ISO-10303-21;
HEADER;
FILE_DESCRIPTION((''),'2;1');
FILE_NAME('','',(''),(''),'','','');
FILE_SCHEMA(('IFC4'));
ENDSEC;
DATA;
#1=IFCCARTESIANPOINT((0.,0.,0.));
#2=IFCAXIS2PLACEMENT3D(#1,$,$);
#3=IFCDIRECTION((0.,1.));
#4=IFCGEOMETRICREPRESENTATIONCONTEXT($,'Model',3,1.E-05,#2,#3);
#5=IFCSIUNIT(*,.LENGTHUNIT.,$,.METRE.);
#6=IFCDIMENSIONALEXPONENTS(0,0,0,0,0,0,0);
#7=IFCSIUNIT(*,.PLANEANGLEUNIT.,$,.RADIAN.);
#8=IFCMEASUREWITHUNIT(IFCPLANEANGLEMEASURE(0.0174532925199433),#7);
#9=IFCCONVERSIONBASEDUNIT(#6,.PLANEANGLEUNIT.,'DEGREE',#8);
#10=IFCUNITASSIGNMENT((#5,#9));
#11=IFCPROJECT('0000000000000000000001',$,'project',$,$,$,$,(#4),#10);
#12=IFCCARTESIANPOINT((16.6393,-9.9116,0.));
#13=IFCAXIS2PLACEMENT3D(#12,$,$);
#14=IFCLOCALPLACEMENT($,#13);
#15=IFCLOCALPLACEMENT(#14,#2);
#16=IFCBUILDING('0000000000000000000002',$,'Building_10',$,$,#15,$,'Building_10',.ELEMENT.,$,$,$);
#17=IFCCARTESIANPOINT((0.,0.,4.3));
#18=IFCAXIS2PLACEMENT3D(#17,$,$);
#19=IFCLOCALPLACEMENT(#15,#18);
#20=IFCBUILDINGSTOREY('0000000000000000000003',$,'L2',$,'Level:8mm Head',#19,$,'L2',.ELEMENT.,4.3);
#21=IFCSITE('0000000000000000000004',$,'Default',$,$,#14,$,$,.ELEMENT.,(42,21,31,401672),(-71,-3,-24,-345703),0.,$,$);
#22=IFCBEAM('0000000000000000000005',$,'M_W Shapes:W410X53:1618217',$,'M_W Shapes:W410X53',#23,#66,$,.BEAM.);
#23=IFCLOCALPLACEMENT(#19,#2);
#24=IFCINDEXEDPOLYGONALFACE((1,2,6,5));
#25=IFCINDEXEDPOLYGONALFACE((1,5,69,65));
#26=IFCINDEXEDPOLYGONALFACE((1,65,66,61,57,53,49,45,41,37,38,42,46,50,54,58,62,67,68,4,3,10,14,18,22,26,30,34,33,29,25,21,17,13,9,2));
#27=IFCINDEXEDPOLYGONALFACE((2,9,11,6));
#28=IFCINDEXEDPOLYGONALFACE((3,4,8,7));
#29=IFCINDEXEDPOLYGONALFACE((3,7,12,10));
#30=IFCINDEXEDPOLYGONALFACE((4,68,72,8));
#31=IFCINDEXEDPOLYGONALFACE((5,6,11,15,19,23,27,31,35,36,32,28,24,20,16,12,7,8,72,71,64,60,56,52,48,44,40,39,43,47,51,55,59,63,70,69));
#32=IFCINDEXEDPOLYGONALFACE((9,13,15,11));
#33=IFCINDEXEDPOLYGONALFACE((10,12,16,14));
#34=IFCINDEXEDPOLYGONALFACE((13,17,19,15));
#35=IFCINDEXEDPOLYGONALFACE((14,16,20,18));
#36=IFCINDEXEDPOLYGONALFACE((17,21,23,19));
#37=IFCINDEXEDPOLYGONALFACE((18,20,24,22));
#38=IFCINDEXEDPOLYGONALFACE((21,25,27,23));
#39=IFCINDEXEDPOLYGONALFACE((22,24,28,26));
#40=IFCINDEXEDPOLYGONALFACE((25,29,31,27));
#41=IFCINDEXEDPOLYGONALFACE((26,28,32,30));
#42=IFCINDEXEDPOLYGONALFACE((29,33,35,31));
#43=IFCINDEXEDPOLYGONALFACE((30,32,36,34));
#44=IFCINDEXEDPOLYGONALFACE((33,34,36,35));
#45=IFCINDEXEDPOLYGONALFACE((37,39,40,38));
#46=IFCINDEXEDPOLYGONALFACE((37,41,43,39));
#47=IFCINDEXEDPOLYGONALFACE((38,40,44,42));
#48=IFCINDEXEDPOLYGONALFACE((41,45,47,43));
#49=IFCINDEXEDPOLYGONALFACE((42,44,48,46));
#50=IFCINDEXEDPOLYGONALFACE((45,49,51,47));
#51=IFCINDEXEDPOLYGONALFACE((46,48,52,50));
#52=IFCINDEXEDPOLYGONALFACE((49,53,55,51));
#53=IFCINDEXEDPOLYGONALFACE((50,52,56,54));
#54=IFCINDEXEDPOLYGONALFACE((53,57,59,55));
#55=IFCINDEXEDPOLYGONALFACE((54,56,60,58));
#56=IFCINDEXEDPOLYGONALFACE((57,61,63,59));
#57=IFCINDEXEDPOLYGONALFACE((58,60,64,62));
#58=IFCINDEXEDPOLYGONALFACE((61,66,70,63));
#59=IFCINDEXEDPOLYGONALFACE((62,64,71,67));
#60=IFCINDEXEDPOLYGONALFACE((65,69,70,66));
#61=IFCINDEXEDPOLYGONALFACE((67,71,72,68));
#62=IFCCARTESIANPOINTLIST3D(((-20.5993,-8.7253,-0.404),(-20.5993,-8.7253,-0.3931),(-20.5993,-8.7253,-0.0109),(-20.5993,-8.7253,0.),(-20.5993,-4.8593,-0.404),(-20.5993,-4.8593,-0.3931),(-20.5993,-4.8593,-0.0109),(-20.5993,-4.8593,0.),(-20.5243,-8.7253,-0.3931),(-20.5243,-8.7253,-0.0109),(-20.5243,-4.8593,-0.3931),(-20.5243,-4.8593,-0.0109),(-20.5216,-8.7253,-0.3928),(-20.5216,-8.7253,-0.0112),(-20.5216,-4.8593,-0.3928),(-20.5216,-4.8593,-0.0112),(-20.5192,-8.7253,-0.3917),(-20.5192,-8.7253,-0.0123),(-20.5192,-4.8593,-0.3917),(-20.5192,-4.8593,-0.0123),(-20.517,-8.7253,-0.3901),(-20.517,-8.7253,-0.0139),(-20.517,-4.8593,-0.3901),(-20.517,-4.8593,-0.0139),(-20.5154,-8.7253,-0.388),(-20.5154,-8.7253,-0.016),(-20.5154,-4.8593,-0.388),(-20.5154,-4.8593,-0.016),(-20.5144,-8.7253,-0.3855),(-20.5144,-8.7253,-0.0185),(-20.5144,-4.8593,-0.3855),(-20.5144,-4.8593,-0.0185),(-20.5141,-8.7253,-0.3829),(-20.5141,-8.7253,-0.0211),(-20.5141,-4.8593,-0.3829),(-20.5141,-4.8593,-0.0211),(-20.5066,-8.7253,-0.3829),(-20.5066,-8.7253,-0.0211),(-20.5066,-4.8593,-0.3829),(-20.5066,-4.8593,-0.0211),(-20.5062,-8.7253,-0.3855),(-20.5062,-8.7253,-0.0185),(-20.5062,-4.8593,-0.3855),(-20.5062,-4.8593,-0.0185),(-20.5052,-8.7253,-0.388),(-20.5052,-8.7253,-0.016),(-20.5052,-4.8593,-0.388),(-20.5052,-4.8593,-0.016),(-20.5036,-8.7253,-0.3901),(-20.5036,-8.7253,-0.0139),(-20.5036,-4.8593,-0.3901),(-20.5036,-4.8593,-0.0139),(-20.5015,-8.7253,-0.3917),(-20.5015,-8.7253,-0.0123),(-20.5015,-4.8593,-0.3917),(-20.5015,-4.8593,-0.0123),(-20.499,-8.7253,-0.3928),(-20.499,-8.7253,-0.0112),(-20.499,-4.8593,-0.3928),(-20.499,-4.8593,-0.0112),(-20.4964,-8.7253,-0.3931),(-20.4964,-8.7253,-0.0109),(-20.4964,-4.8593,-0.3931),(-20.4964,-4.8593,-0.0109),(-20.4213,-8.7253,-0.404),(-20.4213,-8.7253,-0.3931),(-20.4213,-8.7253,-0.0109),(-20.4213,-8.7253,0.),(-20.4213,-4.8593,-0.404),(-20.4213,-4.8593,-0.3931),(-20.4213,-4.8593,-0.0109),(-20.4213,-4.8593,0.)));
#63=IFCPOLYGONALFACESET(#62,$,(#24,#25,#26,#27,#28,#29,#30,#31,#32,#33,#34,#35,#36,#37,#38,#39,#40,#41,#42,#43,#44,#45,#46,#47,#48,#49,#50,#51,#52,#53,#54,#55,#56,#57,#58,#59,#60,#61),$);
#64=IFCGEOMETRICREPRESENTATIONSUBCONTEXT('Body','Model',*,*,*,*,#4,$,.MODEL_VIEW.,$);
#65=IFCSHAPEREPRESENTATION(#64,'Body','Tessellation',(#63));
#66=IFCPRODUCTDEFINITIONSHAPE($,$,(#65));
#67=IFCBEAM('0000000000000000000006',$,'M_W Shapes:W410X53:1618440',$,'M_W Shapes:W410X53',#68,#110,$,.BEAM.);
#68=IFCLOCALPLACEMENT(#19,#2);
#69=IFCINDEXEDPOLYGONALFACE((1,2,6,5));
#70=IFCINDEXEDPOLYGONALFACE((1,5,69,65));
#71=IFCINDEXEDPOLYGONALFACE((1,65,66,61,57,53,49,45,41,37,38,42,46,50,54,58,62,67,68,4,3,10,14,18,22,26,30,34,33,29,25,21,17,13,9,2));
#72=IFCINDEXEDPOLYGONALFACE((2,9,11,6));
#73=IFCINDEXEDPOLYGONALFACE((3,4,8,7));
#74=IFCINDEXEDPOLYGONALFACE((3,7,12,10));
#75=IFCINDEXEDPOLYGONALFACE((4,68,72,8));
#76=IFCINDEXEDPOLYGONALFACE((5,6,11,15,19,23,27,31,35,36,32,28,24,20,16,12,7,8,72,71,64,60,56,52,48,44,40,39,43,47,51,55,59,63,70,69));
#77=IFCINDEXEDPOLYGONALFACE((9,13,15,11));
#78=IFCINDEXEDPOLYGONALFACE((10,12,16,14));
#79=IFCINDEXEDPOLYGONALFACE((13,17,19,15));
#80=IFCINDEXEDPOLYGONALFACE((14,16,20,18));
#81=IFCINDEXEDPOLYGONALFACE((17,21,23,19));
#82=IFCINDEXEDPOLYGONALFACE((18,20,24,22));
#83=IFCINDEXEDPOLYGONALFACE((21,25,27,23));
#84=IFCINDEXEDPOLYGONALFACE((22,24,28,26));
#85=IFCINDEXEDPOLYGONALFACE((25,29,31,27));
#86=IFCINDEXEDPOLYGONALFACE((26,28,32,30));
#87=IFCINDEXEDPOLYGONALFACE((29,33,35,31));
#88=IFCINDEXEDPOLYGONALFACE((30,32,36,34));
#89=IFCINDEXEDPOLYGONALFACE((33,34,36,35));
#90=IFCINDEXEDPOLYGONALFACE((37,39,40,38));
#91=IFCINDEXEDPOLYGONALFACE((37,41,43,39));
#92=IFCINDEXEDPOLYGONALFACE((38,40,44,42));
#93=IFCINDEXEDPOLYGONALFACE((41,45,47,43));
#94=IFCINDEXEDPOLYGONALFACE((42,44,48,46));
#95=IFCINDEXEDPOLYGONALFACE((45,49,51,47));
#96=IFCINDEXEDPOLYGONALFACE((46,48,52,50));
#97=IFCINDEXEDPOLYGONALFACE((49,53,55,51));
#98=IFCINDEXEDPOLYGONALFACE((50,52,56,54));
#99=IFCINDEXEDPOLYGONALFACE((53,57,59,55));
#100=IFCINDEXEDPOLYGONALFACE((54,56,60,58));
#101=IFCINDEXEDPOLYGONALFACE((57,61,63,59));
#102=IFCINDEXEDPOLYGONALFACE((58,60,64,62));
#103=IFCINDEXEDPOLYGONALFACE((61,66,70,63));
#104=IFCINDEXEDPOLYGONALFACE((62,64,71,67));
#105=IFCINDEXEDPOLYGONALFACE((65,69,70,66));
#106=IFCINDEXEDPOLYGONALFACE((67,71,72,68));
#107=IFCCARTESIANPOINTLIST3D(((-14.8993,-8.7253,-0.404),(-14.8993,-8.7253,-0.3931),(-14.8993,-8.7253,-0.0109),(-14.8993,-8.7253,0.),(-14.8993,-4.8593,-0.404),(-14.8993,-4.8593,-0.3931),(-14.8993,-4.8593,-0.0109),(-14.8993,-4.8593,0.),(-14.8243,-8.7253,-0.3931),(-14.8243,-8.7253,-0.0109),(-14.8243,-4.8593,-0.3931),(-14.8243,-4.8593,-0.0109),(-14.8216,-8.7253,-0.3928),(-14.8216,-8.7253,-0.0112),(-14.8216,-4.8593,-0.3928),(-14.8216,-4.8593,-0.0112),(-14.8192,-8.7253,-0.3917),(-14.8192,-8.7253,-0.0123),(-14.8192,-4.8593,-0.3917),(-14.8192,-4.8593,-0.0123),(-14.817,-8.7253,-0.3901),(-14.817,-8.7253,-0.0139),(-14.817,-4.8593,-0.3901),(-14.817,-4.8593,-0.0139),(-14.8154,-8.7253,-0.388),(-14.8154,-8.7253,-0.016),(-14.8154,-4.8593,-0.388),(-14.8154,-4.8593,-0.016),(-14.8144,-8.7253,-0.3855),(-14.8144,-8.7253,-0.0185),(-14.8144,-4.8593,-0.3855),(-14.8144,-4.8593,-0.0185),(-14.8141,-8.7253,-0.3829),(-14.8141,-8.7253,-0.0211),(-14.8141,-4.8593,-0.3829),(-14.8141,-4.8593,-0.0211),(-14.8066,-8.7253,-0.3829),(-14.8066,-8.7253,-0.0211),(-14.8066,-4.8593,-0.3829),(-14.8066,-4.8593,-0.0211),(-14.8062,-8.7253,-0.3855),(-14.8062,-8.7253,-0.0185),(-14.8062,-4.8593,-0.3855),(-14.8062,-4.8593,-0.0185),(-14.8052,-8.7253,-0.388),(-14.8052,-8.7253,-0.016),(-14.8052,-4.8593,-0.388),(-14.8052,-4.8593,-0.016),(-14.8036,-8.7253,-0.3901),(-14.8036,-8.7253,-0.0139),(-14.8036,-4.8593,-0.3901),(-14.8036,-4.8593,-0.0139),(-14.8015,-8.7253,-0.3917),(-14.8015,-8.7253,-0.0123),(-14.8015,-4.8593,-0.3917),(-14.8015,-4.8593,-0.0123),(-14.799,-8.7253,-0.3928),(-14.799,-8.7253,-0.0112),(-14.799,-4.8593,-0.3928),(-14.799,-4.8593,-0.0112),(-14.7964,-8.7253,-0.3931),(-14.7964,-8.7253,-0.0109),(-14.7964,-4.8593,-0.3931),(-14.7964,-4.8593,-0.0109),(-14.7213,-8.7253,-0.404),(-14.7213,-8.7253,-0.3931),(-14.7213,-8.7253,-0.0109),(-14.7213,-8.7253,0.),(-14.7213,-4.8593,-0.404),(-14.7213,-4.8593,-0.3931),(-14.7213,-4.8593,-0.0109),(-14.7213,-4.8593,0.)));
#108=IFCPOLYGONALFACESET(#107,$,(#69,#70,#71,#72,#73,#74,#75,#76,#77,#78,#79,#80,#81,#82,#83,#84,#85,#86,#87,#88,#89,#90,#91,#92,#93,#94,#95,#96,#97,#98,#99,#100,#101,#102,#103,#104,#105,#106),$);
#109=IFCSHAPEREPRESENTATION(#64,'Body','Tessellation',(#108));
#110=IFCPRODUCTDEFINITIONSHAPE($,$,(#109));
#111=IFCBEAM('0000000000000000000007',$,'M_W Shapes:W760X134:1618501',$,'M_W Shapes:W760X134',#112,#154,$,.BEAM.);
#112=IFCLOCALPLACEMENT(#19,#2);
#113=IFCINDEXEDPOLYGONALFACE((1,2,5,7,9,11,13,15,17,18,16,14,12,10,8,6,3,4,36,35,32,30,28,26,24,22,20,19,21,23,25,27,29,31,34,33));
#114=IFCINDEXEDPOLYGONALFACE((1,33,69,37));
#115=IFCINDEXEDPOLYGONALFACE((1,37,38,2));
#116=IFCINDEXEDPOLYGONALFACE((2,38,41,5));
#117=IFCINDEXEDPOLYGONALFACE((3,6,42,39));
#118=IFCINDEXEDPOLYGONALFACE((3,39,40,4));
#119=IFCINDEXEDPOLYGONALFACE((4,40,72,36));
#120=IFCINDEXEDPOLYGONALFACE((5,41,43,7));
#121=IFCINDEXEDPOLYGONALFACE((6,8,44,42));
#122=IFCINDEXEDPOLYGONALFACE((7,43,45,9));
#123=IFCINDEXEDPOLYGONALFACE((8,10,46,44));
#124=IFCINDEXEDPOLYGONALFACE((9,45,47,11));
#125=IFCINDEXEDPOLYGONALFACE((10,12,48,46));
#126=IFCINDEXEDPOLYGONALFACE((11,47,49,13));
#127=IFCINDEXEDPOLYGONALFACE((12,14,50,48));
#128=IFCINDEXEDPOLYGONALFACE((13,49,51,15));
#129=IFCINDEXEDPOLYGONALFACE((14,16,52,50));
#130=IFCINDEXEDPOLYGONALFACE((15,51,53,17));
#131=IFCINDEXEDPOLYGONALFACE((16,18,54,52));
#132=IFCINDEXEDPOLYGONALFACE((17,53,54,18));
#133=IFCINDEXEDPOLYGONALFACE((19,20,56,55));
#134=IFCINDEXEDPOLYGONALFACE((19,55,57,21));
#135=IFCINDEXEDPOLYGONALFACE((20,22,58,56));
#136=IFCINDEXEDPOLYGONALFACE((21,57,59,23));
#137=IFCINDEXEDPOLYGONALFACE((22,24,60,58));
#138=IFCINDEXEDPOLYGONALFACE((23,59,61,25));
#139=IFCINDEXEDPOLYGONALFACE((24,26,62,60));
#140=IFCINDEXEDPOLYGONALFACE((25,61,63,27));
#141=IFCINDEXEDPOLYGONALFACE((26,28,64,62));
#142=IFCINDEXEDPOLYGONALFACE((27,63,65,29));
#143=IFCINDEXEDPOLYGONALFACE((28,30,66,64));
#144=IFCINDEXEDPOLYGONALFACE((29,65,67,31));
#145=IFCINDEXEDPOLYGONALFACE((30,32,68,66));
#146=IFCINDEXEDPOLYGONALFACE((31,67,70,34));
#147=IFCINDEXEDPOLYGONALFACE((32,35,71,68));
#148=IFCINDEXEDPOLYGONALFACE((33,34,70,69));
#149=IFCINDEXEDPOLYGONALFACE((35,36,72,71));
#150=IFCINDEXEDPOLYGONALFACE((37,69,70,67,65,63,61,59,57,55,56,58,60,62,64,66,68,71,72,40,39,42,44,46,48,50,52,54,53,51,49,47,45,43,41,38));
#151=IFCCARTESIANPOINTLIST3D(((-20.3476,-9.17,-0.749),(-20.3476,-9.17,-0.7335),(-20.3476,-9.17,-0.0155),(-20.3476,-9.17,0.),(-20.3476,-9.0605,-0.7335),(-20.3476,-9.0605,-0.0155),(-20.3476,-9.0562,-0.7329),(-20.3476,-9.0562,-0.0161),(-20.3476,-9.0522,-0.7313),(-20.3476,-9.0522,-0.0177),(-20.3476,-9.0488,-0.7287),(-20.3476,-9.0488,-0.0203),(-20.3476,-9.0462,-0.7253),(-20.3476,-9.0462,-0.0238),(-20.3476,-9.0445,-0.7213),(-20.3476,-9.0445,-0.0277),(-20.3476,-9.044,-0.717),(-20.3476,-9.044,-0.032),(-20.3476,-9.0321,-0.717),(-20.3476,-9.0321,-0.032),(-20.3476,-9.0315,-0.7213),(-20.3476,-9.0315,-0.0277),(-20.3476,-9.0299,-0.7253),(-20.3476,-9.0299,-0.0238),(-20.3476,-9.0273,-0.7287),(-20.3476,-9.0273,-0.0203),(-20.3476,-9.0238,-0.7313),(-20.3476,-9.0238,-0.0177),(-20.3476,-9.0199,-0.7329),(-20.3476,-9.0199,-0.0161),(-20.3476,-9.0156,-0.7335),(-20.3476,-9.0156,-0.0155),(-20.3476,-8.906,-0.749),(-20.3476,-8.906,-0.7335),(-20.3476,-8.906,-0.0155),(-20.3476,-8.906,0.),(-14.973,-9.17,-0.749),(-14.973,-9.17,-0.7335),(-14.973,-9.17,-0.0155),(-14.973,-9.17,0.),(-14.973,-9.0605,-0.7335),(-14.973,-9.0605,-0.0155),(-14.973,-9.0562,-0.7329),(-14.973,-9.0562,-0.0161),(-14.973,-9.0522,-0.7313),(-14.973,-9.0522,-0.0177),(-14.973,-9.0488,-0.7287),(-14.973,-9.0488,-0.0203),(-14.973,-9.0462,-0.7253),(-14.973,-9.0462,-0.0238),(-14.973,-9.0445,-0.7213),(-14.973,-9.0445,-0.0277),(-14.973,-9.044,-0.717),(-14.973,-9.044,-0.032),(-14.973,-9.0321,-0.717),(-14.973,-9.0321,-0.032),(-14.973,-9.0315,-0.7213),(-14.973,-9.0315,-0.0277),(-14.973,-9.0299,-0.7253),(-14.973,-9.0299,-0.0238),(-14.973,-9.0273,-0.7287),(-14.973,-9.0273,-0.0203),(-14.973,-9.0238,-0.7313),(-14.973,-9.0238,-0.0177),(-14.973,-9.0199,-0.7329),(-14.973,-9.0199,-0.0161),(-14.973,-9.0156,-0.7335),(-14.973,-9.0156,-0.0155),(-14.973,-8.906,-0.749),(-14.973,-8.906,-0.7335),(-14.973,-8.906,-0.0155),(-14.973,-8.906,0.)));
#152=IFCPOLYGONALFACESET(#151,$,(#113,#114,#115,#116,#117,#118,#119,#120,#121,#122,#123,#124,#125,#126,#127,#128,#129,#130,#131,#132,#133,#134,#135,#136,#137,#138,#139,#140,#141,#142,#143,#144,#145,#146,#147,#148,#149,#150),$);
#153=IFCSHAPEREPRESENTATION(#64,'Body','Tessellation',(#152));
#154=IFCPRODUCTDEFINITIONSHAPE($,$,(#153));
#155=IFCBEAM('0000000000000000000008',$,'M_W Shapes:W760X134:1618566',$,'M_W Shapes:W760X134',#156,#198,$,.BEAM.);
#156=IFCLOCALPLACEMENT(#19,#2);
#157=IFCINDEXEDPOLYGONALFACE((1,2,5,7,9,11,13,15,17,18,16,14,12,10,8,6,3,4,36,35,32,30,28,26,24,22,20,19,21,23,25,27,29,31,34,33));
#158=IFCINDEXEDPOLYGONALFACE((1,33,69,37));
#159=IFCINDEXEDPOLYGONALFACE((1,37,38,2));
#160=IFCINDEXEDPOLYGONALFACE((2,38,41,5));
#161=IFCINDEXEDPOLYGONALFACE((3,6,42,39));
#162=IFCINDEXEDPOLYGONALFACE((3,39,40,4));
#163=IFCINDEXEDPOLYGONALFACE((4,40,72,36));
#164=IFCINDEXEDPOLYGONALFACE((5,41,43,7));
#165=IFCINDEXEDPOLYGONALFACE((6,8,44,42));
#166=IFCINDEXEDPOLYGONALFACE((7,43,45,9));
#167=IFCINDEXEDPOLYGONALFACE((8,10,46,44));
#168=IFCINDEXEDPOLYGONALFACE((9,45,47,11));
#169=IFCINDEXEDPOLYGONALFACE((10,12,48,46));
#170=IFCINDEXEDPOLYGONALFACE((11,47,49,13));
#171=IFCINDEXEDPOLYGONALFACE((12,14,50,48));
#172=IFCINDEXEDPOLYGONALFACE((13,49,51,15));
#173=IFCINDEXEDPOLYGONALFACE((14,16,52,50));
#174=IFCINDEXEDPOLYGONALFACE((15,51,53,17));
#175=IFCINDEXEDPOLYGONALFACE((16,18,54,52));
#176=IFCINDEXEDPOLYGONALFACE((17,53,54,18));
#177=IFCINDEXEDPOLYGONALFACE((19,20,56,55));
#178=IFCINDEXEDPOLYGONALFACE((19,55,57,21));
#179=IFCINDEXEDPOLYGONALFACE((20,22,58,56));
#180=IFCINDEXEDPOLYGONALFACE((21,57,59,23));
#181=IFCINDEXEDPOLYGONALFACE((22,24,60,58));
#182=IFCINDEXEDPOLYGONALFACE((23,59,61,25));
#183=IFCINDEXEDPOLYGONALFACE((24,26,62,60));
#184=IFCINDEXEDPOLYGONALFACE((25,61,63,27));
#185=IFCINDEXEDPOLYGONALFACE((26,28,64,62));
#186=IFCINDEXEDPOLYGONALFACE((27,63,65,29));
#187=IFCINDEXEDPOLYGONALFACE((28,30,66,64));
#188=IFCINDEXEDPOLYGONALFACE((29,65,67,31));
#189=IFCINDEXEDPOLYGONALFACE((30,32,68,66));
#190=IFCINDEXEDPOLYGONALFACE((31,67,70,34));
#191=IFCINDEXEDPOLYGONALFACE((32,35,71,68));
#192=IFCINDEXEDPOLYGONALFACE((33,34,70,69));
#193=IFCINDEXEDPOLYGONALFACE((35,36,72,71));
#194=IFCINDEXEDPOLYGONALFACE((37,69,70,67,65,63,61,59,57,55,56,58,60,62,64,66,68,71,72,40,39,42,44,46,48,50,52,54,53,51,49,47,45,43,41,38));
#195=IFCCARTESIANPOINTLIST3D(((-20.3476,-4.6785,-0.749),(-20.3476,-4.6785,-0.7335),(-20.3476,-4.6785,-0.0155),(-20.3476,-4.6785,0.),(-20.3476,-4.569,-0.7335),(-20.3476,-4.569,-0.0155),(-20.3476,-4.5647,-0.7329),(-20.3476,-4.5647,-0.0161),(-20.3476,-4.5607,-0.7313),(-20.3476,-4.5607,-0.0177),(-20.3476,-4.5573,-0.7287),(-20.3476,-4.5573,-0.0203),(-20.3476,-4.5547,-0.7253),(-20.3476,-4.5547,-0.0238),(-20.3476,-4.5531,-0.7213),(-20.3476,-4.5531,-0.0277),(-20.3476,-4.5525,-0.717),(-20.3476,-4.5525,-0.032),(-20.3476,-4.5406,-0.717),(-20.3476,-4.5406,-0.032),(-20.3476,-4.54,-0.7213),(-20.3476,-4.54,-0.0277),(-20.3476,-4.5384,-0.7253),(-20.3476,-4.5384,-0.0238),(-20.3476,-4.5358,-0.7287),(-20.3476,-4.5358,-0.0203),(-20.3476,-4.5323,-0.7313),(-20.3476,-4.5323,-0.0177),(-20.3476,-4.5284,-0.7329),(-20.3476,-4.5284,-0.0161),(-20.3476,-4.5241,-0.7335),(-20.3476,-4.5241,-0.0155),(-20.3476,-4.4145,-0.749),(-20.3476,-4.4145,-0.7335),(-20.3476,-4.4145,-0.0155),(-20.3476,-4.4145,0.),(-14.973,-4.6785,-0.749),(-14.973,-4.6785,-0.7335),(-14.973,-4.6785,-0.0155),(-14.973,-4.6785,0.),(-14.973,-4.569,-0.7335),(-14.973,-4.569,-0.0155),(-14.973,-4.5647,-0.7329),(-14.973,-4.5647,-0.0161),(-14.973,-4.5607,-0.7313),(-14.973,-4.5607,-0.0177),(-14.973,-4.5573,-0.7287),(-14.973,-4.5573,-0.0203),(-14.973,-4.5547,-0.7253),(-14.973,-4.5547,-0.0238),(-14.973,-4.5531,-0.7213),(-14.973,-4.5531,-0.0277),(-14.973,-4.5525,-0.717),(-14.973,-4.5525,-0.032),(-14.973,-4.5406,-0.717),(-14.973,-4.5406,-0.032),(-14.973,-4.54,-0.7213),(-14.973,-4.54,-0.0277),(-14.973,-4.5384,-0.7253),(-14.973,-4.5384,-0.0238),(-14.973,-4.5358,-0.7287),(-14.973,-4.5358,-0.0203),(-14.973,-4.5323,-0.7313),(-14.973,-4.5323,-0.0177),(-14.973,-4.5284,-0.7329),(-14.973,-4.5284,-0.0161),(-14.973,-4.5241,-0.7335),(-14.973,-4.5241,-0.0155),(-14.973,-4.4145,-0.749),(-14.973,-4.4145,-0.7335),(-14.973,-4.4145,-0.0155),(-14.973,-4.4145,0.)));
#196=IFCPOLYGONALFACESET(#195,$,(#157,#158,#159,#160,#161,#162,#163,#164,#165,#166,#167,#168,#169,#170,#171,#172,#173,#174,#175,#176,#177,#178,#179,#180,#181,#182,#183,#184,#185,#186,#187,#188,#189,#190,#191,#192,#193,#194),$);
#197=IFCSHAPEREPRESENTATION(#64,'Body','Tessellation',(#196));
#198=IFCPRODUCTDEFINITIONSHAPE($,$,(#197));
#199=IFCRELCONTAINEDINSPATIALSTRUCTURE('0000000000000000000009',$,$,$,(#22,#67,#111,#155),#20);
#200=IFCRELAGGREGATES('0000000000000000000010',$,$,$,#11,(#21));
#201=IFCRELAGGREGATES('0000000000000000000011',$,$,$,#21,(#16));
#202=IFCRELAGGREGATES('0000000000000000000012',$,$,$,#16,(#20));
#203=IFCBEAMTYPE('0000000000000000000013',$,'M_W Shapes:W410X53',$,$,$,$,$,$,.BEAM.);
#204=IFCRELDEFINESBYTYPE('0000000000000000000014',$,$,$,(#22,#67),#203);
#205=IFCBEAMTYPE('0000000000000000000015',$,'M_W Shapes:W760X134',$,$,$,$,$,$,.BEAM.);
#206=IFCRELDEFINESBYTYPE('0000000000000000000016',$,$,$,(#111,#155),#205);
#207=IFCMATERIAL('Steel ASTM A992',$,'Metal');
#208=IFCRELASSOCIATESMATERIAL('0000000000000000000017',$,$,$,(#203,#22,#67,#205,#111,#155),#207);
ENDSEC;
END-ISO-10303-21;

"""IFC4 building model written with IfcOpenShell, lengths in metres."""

from ifc_helpers import new_model, entity, si_unit, converted_unit, direction, frame, origin, place, context, subcontext, project, spatial, line, arc, indexed_curve, outline, extrude, source, transform, mapped, material, type_object, type_shapes, element, save


model = new_model("IFC4")

# Units and contexts
model_context = context("Model", 3, precision=1e-05, world=origin(), true_north=direction((0.0, 1.0)))
body_context = subcontext(model_context, "Body", "Model", "MODEL_VIEW")
ifc_project = project(units=[si_unit("LENGTHUNIT", "METRE"), converted_unit("PLANEANGLEUNIT", "DEGREE", entity("IfcPlaneAngleMeasure", 0.0174532925199433), si_unit("PLANEANGLEUNIT", "RADIAN"), dimensions=[0, 0, 0, 0, 0, 0, 0])], contexts=[model_context])

# Site, building, storey
site_placement = place(None, frame((16.6393, -9.9116, 0.0)))
site = spatial("IfcSite", under=ifc_project, at=site_placement, Name="Default", CompositionType="ELEMENT", RefLatitude=(42, 21, 31, 401672), RefLongitude=(-71, -3, -24, -345703), RefElevation=0.0)
building_placement = place(site_placement, origin())
building = spatial("IfcBuilding", under=site, at=building_placement, Name="Building_10", LongName="Building_10", CompositionType="ELEMENT")
storey_placement = place(building_placement, frame((0.0, 0.0, 4.3)))
storey = spatial("IfcBuildingStorey", under=building, at=storey_placement, Name="L2", ObjectType="Level:8mm Head", LongName="L2", CompositionType="ELEMENT", Elevation=4.3)

# Beams
ifc_material_1 = material(Name="Steel ASTM A992", Category="Metal")
beam_type_1 = type_object("IfcBeamType", Name="M_W Shapes:W410X53", PredefinedType="BEAM", material=ifc_material_1)
shared_shape_1 = source(origin(), body_context, "Body", "SweptSolid", [
    extrude(outline(indexed_curve([(-0.089, -0.1911), (-0.089, -0.202), (0.089, -0.202), (0.089, -0.1911), (0.0139, -0.1911), (0.0067, -0.1881), (0.0037, -0.1809), (0.0037, 0.1809), (0.0067, 0.1881), (0.0139, 0.1911), (0.089, 0.1911), (0.089, 0.202), (-0.089, 0.202), (-0.089, 0.1911), (-0.0139, 0.1911), (-0.0067, 0.1881), (-0.0037, 0.1809), (-0.0037, -0.1809), (-0.0067, -0.1881), (-0.0139, -0.1911)], segments=[line(1, 2, 3, 4, 5), arc(5, 6, 7), line(7, 8), arc(8, 9, 10), line(10, 11, 12, 13, 14, 15), arc(15, 16, 17), line(17, 18), arc(18, 19, 20), line(20, 1)], self_intersect=False)), frame((-1.933, 0.0, 0.0), z_axis=(-1.0, 0.0, 0.0), x_axis=(0.0, -1.0, 0.0)), (0.0, 0.0, -1.0), 3.866),
])
type_shapes(beam_type_1, [shared_shape_1])
for number, where, z_axis, x_axis, name in (
    (1, (-20.5103, -6.7923, -0.202), (0.0, 0.0, 1.0), (0.0, 1.0, 0.0), "M_W Shapes:W410X53:1618217"),
    (2, (-14.8103, -6.7923, -0.202), (0.0, 0.0, 1.0), (0.0, 1.0, 0.0), "M_W Shapes:W410X53:1618440"),
):
    element("IfcBeam", number, at=place(storey_placement, frame(where, z_axis=z_axis, x_axis=x_axis)), inside=storey, type_object=beam_type_1, material=ifc_material_1, Name=name, ObjectType="M_W Shapes:W410X53", PredefinedType="BEAM", context=body_context, shape_type="MappedRepresentation", body=[
        mapped(shared_shape_1, transform((0.0, 0.0, 0.0), scale=1.0)),
    ])
beam_type_2 = type_object("IfcBeamType", Name="M_W Shapes:W760X134", PredefinedType="BEAM", material=ifc_material_1)
shared_shape_2 = source(origin(), body_context, "Body", "SweptSolid", [
    extrude(outline(indexed_curve([(-0.132, -0.359), (-0.132, -0.3745), (0.132, -0.3745), (0.132, -0.359), (0.0224, -0.359), (0.0108, -0.3542), (0.0059, -0.3425), (0.0059, 0.3425), (0.0108, 0.3542), (0.0225, 0.359), (0.132, 0.359), (0.132, 0.3745), (-0.132, 0.3745), (-0.132, 0.359), (-0.0225, 0.359), (-0.0108, 0.3542), (-0.006, 0.3425), (-0.006, -0.3425), (-0.0108, -0.3542), (-0.0225, -0.359)], segments=[line(1, 2, 3, 4, 5), arc(5, 6, 7), line(7, 8), arc(8, 9, 10), line(10, 11, 12, 13, 14, 15), arc(15, 16, 17), line(17, 18), arc(18, 19, 20), line(20, 1)], self_intersect=False)), frame((-2.6873, 0.0, 0.0), z_axis=(-1.0, 0.0, 0.0), x_axis=(0.0, -1.0, 0.0)), (0.0, 0.0, -1.0), 5.3746),
])
type_shapes(beam_type_2, [shared_shape_2])
for number, where, name in (
    (3, (-17.6603, -9.038, -0.3745), "M_W Shapes:W760X134:1618501"),
    (4, (-17.6603, -4.5465, -0.3745), "M_W Shapes:W760X134:1618566"),
):
    element("IfcBeam", number, at=place(storey_placement, frame(where)), inside=storey, type_object=beam_type_2, material=ifc_material_1, Name=name, ObjectType="M_W Shapes:W760X134", PredefinedType="BEAM", context=body_context, shape_type="MappedRepresentation", body=[
        mapped(shared_shape_2, transform((0.0, 0.0, 0.0), scale=1.0)),
    ])

save(model, "model.ifc")
